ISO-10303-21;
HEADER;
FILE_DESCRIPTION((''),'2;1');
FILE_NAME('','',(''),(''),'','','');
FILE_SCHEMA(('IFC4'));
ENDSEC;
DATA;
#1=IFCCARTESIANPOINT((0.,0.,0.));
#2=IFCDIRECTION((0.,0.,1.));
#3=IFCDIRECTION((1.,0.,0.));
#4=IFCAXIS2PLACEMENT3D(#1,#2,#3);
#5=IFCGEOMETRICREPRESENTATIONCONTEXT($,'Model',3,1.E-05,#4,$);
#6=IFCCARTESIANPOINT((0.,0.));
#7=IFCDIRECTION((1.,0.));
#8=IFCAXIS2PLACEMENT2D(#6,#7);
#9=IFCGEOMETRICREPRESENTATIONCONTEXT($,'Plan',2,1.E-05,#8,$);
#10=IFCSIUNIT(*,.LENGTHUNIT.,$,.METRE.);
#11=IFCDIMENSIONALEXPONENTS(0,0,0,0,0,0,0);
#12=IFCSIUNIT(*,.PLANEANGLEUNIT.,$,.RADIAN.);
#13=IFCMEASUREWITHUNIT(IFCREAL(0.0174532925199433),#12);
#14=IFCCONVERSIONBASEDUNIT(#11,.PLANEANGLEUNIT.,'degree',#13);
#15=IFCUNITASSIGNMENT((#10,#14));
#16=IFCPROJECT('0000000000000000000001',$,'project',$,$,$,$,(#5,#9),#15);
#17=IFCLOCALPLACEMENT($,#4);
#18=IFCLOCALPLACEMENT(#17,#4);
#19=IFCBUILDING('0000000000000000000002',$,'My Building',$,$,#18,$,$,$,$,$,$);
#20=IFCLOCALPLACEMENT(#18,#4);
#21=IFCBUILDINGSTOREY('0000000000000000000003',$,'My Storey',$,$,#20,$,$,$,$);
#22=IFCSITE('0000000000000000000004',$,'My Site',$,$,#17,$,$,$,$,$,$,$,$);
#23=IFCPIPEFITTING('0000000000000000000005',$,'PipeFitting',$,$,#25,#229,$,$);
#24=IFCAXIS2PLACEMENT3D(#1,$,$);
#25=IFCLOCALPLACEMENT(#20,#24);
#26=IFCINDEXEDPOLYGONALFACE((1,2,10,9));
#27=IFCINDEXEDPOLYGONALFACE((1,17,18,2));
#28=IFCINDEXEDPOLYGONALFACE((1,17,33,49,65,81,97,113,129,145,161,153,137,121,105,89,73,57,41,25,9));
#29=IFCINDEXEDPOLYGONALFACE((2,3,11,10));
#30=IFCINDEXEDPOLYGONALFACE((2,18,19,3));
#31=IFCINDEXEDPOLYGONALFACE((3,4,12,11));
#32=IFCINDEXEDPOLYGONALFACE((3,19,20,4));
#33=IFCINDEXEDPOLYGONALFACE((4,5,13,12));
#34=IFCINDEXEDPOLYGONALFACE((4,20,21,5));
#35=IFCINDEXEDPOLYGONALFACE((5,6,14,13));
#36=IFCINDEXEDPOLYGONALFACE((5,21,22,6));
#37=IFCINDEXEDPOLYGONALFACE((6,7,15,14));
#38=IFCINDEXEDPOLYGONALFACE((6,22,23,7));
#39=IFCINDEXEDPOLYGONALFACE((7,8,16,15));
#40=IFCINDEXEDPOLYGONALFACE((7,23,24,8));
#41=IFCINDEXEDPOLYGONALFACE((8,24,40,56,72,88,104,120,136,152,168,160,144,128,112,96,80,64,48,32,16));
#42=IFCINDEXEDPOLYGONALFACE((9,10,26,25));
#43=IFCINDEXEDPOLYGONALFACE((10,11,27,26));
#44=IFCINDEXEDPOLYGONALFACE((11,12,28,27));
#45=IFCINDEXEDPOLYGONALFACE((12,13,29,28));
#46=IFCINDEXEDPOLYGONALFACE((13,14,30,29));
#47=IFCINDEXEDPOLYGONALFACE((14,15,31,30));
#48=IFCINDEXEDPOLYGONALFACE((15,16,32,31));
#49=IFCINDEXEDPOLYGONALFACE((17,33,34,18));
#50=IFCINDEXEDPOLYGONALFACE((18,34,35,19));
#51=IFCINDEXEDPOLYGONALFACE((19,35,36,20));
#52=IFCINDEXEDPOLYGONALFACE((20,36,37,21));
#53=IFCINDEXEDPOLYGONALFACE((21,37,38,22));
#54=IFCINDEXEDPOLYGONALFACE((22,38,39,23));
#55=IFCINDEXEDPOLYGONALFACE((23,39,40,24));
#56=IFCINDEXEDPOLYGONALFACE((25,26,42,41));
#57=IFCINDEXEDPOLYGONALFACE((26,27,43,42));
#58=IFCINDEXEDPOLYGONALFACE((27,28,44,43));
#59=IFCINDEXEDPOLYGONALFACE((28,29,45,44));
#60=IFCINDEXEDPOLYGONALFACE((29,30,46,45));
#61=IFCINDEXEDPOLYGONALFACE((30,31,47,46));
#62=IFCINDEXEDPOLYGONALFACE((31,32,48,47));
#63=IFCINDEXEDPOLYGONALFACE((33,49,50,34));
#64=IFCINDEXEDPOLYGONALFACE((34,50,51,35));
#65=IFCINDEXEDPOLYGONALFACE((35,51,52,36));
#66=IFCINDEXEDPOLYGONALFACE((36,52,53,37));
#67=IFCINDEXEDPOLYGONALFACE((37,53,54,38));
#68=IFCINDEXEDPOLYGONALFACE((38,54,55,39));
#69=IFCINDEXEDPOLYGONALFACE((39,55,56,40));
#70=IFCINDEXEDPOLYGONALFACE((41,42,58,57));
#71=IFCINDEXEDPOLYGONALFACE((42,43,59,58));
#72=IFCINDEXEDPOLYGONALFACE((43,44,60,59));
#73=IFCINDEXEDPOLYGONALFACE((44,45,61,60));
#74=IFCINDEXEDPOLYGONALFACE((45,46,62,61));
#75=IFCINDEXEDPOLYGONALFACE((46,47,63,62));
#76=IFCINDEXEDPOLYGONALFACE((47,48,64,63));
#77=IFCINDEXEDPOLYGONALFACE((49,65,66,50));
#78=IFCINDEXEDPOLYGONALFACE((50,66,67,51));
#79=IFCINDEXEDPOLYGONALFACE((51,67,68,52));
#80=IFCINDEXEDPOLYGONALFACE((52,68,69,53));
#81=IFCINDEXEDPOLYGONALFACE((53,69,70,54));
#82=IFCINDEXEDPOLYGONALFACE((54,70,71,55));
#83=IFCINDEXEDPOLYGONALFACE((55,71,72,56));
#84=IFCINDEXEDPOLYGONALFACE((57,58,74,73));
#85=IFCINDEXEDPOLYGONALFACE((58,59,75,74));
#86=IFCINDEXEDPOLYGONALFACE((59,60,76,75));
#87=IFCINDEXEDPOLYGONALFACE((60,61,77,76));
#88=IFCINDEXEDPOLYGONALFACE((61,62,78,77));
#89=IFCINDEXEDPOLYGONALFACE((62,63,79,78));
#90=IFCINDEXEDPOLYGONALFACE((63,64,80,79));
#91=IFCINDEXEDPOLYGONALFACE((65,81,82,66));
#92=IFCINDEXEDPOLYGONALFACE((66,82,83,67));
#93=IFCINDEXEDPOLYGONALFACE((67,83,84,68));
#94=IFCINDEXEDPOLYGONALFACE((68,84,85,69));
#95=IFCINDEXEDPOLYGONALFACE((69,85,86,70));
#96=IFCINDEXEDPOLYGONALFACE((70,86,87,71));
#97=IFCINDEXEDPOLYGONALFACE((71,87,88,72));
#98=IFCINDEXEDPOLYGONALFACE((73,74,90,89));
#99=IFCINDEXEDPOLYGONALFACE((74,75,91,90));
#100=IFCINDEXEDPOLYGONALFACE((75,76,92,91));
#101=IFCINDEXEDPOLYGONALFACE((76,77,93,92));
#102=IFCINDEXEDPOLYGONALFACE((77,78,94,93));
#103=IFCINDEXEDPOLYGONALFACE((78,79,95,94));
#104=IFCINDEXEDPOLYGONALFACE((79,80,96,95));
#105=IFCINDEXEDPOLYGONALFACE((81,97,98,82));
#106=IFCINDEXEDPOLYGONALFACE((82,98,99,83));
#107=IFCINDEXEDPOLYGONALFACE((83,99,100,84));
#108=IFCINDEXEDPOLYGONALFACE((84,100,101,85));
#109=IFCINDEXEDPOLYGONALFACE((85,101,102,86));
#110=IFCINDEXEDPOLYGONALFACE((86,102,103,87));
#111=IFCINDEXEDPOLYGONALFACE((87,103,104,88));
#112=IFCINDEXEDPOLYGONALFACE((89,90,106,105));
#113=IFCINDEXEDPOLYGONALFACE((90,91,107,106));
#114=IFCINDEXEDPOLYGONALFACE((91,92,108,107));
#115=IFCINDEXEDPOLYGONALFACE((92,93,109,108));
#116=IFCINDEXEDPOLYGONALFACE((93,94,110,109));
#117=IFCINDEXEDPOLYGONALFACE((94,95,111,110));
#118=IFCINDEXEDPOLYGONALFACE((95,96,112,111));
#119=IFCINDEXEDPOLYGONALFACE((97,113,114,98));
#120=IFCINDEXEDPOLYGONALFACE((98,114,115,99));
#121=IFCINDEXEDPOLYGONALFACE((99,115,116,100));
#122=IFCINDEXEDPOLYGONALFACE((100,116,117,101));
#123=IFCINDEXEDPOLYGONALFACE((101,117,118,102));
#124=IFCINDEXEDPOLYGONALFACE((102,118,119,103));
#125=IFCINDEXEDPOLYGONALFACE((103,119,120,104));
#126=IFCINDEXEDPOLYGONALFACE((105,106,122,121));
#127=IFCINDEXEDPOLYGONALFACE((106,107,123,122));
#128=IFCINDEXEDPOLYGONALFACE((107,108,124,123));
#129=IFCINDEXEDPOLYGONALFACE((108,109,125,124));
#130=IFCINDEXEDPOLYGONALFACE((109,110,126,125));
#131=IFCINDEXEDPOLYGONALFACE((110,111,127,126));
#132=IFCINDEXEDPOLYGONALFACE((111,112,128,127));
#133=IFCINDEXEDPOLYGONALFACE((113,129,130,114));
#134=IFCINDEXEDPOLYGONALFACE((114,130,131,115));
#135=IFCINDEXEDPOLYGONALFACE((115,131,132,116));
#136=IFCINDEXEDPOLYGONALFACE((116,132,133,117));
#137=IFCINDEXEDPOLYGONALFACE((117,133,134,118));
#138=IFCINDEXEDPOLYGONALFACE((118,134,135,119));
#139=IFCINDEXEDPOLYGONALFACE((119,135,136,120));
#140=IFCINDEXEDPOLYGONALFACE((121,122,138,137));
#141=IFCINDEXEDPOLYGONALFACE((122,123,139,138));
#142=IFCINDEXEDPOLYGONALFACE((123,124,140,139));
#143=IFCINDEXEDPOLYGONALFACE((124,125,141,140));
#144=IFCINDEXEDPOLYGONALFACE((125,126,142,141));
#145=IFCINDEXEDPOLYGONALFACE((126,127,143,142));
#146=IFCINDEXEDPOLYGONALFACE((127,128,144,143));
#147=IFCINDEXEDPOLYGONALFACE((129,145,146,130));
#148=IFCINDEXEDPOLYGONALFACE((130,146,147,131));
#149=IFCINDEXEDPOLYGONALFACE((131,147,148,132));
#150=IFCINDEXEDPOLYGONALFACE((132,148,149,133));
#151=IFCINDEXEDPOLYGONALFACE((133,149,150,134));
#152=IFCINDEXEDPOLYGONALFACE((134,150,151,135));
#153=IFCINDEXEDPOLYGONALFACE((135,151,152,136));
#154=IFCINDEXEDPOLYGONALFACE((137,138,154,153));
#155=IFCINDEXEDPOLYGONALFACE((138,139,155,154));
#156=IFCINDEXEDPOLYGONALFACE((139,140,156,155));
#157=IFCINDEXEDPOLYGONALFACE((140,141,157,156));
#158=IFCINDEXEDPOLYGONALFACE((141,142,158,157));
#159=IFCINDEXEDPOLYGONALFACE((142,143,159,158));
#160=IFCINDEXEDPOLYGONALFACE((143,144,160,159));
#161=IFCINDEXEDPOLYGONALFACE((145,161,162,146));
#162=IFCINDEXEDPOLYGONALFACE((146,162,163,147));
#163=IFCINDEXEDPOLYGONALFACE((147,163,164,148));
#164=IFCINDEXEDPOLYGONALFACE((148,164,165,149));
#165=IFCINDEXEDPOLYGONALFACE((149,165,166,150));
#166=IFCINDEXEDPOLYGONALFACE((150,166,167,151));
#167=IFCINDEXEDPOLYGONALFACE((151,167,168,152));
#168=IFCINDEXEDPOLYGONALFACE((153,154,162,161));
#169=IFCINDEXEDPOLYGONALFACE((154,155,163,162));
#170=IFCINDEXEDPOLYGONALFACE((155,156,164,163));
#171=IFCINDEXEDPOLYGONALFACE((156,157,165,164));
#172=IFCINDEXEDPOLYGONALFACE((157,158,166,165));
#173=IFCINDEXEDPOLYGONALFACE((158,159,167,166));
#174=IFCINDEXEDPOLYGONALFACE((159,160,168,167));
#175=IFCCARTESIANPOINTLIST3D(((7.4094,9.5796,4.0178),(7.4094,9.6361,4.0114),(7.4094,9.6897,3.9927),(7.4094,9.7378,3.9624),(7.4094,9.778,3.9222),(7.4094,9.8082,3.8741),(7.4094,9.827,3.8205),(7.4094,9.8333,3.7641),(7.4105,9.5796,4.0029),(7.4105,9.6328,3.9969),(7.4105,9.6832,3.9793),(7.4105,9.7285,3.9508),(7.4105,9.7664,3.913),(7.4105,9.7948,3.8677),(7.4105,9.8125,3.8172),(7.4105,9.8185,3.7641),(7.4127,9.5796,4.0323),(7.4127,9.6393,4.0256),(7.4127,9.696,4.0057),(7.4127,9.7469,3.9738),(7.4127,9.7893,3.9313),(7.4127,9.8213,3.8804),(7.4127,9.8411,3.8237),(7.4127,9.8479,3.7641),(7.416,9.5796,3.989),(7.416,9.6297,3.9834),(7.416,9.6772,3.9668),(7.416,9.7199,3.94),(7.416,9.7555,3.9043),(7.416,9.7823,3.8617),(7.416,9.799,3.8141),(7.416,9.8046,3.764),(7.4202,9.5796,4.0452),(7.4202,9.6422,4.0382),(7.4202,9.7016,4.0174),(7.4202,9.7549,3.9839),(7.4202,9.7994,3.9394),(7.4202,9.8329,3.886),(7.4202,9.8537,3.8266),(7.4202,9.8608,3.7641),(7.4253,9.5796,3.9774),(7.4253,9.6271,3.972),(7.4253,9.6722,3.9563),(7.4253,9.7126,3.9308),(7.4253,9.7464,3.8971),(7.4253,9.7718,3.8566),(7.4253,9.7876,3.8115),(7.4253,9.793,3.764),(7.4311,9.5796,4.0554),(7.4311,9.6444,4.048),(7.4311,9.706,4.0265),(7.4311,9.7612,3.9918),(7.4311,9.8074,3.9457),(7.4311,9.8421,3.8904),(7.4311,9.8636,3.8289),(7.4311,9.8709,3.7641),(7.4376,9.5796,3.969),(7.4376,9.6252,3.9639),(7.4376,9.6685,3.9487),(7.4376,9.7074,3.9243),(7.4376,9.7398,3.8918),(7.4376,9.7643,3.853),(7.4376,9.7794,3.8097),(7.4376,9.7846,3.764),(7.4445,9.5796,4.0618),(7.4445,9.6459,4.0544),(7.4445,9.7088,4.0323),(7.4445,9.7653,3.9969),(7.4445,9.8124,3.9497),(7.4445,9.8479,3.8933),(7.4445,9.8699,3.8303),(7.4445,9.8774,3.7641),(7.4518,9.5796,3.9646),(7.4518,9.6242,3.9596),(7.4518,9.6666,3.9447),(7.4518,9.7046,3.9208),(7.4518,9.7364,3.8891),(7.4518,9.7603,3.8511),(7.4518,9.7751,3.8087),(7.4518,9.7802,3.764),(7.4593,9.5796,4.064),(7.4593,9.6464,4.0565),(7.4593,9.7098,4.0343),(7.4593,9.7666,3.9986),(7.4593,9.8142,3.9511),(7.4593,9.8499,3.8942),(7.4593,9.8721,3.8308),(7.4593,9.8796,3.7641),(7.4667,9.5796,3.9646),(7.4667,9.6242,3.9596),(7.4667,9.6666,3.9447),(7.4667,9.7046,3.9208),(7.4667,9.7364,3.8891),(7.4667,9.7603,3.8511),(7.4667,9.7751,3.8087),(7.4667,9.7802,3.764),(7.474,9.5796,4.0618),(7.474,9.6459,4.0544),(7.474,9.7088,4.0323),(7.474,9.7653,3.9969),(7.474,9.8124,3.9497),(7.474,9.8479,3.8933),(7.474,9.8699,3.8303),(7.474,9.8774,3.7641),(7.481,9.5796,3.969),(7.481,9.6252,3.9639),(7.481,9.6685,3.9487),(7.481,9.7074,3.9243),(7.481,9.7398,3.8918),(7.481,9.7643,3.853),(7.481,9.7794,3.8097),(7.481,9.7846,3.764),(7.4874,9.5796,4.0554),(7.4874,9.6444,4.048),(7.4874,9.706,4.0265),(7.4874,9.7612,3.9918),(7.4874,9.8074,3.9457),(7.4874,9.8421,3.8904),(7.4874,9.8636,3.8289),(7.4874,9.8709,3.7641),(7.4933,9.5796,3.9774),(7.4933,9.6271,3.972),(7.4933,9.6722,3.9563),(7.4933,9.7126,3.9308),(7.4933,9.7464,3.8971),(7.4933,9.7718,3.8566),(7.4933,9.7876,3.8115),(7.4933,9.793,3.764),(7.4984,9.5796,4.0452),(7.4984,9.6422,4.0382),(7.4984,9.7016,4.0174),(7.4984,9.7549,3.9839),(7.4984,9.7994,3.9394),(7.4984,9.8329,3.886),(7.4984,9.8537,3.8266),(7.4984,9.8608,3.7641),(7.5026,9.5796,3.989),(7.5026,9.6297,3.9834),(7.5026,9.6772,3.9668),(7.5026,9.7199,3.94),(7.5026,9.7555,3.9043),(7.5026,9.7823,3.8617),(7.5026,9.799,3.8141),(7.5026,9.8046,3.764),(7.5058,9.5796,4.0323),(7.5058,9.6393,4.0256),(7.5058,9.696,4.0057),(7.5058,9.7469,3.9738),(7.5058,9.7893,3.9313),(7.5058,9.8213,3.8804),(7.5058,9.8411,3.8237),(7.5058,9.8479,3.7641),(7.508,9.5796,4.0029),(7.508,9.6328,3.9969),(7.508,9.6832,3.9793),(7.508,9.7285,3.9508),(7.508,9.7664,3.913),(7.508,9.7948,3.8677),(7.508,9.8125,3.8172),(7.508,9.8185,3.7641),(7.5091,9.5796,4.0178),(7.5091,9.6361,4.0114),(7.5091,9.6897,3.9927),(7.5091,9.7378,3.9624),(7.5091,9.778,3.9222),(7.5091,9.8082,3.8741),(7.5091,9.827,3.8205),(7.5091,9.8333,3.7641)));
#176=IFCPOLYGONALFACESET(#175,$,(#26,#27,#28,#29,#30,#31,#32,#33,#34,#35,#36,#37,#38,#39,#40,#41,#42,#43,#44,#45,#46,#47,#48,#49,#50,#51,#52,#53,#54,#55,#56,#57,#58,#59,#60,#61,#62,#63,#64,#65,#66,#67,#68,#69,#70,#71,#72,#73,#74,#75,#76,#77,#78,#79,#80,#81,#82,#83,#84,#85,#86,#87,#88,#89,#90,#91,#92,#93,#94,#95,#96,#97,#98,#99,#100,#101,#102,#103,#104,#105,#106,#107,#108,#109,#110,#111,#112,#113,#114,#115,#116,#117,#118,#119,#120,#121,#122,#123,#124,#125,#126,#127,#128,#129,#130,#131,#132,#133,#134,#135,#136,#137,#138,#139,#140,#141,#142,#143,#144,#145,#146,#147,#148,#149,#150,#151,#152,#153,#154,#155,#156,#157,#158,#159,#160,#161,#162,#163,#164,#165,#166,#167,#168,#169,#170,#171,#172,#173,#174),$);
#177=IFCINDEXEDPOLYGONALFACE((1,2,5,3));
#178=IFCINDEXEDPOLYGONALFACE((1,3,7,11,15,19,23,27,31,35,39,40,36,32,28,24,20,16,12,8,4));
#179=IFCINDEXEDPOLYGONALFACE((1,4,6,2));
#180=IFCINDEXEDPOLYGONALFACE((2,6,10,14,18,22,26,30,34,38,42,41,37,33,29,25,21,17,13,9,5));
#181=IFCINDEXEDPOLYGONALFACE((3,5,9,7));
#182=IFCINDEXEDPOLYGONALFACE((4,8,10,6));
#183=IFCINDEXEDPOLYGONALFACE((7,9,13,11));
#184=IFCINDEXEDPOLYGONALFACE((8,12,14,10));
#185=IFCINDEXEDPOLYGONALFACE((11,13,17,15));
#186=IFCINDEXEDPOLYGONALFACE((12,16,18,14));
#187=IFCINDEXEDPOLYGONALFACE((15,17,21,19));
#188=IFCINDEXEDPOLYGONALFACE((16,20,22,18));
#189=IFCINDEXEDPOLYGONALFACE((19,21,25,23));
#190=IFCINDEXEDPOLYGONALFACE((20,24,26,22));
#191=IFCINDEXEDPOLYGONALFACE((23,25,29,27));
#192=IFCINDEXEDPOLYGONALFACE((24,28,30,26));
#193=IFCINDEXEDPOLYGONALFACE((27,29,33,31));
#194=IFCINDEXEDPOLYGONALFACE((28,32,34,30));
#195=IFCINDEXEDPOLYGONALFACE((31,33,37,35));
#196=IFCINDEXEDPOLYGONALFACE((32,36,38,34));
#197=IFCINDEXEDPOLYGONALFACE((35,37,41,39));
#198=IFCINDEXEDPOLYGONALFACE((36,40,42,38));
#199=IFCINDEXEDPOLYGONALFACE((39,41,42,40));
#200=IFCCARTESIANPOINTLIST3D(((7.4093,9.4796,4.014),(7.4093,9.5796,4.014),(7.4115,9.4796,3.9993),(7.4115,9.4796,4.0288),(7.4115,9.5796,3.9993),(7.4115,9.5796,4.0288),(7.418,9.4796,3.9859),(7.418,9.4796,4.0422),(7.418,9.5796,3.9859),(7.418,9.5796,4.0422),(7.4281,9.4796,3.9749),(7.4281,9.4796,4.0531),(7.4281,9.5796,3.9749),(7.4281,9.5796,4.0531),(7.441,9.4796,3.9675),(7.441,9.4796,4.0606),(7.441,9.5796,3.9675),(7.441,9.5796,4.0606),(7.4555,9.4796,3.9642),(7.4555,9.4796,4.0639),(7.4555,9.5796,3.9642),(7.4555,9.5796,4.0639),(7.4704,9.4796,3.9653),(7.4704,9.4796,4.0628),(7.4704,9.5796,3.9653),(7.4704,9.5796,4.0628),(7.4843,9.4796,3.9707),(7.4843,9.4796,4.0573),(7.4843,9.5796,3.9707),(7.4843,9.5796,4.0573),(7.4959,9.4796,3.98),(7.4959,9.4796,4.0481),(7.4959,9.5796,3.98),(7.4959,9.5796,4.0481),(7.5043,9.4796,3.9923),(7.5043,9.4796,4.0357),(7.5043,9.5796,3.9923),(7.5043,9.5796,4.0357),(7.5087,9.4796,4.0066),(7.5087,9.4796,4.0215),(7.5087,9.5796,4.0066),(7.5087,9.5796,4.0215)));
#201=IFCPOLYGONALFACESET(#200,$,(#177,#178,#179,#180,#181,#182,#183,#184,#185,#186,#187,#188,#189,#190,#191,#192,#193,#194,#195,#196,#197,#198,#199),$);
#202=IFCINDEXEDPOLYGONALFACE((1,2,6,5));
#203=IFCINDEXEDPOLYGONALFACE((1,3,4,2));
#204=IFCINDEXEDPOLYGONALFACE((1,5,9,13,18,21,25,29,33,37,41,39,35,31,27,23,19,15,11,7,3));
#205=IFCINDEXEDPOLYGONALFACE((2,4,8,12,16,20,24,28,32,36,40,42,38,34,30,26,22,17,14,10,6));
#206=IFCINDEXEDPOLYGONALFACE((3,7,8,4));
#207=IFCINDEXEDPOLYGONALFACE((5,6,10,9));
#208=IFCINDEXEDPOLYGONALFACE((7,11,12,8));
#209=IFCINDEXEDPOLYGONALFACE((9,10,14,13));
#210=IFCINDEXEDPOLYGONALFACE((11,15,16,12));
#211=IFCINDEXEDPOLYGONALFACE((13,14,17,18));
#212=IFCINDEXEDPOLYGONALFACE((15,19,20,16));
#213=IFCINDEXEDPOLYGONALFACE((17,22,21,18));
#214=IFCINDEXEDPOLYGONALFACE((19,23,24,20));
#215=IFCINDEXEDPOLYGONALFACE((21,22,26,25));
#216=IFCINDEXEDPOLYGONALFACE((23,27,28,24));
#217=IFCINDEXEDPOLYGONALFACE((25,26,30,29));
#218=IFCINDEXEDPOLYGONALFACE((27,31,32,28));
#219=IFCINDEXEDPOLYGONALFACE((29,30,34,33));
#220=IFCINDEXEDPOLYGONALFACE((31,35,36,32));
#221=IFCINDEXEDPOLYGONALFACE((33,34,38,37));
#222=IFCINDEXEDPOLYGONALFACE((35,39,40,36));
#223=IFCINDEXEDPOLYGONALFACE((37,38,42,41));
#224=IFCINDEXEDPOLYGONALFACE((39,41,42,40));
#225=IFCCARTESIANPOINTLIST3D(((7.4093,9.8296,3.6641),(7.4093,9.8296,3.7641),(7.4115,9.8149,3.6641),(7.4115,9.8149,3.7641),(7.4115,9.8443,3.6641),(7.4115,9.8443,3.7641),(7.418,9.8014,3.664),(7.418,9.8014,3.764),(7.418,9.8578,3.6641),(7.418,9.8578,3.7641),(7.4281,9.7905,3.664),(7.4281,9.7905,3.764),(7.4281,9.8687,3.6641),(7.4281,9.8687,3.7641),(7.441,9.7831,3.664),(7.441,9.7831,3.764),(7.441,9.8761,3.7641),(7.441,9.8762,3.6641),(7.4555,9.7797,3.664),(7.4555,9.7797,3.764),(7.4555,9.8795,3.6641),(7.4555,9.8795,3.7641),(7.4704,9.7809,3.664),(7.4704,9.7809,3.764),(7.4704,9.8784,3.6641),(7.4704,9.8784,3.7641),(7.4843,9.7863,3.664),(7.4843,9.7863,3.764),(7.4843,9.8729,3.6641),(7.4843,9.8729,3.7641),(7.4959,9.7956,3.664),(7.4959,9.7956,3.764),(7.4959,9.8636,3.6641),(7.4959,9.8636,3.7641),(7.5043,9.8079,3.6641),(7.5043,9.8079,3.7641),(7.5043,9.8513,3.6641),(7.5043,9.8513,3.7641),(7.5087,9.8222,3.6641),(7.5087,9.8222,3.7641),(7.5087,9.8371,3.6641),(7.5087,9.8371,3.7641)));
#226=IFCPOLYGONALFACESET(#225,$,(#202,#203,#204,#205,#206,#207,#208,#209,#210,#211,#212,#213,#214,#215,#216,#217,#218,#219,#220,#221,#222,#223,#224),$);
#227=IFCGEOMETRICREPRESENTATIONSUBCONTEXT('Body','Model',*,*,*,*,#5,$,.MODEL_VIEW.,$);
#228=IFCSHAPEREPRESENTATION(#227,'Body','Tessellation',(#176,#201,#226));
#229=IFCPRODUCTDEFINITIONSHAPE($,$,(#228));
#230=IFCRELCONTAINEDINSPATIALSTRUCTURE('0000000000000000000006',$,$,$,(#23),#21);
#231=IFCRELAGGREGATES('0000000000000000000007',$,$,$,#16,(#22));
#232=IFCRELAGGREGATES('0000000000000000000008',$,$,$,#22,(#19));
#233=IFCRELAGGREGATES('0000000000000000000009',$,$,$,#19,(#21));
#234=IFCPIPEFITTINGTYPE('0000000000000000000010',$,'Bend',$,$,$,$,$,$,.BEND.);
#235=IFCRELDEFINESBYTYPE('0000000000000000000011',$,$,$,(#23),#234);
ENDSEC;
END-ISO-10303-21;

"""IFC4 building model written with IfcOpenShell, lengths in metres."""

from ifc_helpers import new_model, entity, si_unit, converted_unit, frame, origin_with_axes, origin_2d_with_axis, place, context, subcontext, project, spatial, circle, extrude, source, transform, mapped, type_object, type_shapes, element, save


model = new_model("IFC4")

# Units and contexts
model_context = context("Model", 3, precision=1e-05, world=origin_with_axes())
plan_context = context("Plan", 2, precision=1e-05, world=origin_2d_with_axis())
body_context = subcontext(model_context, "Body", "Model", "MODEL_VIEW")
ifc_project = project(units=[si_unit("LENGTHUNIT", "METRE"), converted_unit("PLANEANGLEUNIT", "degree", entity("IfcReal", 0.0174532925199433), si_unit("PLANEANGLEUNIT", "RADIAN"), dimensions=[0, 0, 0, 0, 0, 0, 0])], contexts=[model_context, plan_context])

# Site, building, storey
site_placement = place(None, origin_with_axes())
site = spatial("IfcSite", under=ifc_project, at=site_placement, Name="My Site")
building_placement = place(site_placement, origin_with_axes())
building = spatial("IfcBuilding", under=site, at=building_placement, Name="My Building")
storey_placement = place(building_placement, origin_with_axes())
storey = spatial("IfcBuildingStorey", under=building, at=storey_placement, Name="My Storey")

# Pipe fitting
pipe_fitting_type_1 = type_object("IfcPipeFittingType", Name="Bend", PredefinedType="BEND")
shared_shape_1 = source(origin_with_axes(), body_context, "Body", "SolidModel", [
    entity("IfcSweptDiskSolid", entity("IfcIndexedPolyCurve", entity("IfcCartesianPointList3D", [[0.0, 0.0, 0.1], [0.0, -0.0732, 0.2768], [0.0, -0.25, 0.35]]), [entity("IfcArcIndex", [1, 2, 3])]), 0.05),
    extrude(circle(Radius=0.05), origin_with_axes(), (0.0, 0.0, 1.0), 0.1),
    extrude(circle(Radius=0.05), frame((0.0, -0.25, 0.35), z_axis=(0.0, -1.0, 0.000038), x_axis=(1.0, 0.0, 0.0)), (0.0, 0.0, 1.0), 0.1),
])
type_shapes(pipe_fitting_type_1, [shared_shape_1])
for number, where, z_axis, x_axis, name in (
    (1, (7.4593, 9.4796, 4.014), (0.0, 1.0, 0.0), (-1.0, 0.0, 0.0), "PipeFitting"),
):
    element("IfcPipeFitting", number, at=place(storey_placement, frame(where, z_axis=z_axis, x_axis=x_axis)), inside=storey, type_object=pipe_fitting_type_1, Name=name, context=body_context, shape_type="MappedRepresentation", body=[
        mapped(shared_shape_1, transform((0.0, 0.0, 0.0), x_axis=(1.0, 0.0, 0.0), y_axis=(0.0, 1.0, 0.0), z_axis=(0.0, 0.0, 1.0), scale=1.0)),
    ])

save(model, "model.ifc")
